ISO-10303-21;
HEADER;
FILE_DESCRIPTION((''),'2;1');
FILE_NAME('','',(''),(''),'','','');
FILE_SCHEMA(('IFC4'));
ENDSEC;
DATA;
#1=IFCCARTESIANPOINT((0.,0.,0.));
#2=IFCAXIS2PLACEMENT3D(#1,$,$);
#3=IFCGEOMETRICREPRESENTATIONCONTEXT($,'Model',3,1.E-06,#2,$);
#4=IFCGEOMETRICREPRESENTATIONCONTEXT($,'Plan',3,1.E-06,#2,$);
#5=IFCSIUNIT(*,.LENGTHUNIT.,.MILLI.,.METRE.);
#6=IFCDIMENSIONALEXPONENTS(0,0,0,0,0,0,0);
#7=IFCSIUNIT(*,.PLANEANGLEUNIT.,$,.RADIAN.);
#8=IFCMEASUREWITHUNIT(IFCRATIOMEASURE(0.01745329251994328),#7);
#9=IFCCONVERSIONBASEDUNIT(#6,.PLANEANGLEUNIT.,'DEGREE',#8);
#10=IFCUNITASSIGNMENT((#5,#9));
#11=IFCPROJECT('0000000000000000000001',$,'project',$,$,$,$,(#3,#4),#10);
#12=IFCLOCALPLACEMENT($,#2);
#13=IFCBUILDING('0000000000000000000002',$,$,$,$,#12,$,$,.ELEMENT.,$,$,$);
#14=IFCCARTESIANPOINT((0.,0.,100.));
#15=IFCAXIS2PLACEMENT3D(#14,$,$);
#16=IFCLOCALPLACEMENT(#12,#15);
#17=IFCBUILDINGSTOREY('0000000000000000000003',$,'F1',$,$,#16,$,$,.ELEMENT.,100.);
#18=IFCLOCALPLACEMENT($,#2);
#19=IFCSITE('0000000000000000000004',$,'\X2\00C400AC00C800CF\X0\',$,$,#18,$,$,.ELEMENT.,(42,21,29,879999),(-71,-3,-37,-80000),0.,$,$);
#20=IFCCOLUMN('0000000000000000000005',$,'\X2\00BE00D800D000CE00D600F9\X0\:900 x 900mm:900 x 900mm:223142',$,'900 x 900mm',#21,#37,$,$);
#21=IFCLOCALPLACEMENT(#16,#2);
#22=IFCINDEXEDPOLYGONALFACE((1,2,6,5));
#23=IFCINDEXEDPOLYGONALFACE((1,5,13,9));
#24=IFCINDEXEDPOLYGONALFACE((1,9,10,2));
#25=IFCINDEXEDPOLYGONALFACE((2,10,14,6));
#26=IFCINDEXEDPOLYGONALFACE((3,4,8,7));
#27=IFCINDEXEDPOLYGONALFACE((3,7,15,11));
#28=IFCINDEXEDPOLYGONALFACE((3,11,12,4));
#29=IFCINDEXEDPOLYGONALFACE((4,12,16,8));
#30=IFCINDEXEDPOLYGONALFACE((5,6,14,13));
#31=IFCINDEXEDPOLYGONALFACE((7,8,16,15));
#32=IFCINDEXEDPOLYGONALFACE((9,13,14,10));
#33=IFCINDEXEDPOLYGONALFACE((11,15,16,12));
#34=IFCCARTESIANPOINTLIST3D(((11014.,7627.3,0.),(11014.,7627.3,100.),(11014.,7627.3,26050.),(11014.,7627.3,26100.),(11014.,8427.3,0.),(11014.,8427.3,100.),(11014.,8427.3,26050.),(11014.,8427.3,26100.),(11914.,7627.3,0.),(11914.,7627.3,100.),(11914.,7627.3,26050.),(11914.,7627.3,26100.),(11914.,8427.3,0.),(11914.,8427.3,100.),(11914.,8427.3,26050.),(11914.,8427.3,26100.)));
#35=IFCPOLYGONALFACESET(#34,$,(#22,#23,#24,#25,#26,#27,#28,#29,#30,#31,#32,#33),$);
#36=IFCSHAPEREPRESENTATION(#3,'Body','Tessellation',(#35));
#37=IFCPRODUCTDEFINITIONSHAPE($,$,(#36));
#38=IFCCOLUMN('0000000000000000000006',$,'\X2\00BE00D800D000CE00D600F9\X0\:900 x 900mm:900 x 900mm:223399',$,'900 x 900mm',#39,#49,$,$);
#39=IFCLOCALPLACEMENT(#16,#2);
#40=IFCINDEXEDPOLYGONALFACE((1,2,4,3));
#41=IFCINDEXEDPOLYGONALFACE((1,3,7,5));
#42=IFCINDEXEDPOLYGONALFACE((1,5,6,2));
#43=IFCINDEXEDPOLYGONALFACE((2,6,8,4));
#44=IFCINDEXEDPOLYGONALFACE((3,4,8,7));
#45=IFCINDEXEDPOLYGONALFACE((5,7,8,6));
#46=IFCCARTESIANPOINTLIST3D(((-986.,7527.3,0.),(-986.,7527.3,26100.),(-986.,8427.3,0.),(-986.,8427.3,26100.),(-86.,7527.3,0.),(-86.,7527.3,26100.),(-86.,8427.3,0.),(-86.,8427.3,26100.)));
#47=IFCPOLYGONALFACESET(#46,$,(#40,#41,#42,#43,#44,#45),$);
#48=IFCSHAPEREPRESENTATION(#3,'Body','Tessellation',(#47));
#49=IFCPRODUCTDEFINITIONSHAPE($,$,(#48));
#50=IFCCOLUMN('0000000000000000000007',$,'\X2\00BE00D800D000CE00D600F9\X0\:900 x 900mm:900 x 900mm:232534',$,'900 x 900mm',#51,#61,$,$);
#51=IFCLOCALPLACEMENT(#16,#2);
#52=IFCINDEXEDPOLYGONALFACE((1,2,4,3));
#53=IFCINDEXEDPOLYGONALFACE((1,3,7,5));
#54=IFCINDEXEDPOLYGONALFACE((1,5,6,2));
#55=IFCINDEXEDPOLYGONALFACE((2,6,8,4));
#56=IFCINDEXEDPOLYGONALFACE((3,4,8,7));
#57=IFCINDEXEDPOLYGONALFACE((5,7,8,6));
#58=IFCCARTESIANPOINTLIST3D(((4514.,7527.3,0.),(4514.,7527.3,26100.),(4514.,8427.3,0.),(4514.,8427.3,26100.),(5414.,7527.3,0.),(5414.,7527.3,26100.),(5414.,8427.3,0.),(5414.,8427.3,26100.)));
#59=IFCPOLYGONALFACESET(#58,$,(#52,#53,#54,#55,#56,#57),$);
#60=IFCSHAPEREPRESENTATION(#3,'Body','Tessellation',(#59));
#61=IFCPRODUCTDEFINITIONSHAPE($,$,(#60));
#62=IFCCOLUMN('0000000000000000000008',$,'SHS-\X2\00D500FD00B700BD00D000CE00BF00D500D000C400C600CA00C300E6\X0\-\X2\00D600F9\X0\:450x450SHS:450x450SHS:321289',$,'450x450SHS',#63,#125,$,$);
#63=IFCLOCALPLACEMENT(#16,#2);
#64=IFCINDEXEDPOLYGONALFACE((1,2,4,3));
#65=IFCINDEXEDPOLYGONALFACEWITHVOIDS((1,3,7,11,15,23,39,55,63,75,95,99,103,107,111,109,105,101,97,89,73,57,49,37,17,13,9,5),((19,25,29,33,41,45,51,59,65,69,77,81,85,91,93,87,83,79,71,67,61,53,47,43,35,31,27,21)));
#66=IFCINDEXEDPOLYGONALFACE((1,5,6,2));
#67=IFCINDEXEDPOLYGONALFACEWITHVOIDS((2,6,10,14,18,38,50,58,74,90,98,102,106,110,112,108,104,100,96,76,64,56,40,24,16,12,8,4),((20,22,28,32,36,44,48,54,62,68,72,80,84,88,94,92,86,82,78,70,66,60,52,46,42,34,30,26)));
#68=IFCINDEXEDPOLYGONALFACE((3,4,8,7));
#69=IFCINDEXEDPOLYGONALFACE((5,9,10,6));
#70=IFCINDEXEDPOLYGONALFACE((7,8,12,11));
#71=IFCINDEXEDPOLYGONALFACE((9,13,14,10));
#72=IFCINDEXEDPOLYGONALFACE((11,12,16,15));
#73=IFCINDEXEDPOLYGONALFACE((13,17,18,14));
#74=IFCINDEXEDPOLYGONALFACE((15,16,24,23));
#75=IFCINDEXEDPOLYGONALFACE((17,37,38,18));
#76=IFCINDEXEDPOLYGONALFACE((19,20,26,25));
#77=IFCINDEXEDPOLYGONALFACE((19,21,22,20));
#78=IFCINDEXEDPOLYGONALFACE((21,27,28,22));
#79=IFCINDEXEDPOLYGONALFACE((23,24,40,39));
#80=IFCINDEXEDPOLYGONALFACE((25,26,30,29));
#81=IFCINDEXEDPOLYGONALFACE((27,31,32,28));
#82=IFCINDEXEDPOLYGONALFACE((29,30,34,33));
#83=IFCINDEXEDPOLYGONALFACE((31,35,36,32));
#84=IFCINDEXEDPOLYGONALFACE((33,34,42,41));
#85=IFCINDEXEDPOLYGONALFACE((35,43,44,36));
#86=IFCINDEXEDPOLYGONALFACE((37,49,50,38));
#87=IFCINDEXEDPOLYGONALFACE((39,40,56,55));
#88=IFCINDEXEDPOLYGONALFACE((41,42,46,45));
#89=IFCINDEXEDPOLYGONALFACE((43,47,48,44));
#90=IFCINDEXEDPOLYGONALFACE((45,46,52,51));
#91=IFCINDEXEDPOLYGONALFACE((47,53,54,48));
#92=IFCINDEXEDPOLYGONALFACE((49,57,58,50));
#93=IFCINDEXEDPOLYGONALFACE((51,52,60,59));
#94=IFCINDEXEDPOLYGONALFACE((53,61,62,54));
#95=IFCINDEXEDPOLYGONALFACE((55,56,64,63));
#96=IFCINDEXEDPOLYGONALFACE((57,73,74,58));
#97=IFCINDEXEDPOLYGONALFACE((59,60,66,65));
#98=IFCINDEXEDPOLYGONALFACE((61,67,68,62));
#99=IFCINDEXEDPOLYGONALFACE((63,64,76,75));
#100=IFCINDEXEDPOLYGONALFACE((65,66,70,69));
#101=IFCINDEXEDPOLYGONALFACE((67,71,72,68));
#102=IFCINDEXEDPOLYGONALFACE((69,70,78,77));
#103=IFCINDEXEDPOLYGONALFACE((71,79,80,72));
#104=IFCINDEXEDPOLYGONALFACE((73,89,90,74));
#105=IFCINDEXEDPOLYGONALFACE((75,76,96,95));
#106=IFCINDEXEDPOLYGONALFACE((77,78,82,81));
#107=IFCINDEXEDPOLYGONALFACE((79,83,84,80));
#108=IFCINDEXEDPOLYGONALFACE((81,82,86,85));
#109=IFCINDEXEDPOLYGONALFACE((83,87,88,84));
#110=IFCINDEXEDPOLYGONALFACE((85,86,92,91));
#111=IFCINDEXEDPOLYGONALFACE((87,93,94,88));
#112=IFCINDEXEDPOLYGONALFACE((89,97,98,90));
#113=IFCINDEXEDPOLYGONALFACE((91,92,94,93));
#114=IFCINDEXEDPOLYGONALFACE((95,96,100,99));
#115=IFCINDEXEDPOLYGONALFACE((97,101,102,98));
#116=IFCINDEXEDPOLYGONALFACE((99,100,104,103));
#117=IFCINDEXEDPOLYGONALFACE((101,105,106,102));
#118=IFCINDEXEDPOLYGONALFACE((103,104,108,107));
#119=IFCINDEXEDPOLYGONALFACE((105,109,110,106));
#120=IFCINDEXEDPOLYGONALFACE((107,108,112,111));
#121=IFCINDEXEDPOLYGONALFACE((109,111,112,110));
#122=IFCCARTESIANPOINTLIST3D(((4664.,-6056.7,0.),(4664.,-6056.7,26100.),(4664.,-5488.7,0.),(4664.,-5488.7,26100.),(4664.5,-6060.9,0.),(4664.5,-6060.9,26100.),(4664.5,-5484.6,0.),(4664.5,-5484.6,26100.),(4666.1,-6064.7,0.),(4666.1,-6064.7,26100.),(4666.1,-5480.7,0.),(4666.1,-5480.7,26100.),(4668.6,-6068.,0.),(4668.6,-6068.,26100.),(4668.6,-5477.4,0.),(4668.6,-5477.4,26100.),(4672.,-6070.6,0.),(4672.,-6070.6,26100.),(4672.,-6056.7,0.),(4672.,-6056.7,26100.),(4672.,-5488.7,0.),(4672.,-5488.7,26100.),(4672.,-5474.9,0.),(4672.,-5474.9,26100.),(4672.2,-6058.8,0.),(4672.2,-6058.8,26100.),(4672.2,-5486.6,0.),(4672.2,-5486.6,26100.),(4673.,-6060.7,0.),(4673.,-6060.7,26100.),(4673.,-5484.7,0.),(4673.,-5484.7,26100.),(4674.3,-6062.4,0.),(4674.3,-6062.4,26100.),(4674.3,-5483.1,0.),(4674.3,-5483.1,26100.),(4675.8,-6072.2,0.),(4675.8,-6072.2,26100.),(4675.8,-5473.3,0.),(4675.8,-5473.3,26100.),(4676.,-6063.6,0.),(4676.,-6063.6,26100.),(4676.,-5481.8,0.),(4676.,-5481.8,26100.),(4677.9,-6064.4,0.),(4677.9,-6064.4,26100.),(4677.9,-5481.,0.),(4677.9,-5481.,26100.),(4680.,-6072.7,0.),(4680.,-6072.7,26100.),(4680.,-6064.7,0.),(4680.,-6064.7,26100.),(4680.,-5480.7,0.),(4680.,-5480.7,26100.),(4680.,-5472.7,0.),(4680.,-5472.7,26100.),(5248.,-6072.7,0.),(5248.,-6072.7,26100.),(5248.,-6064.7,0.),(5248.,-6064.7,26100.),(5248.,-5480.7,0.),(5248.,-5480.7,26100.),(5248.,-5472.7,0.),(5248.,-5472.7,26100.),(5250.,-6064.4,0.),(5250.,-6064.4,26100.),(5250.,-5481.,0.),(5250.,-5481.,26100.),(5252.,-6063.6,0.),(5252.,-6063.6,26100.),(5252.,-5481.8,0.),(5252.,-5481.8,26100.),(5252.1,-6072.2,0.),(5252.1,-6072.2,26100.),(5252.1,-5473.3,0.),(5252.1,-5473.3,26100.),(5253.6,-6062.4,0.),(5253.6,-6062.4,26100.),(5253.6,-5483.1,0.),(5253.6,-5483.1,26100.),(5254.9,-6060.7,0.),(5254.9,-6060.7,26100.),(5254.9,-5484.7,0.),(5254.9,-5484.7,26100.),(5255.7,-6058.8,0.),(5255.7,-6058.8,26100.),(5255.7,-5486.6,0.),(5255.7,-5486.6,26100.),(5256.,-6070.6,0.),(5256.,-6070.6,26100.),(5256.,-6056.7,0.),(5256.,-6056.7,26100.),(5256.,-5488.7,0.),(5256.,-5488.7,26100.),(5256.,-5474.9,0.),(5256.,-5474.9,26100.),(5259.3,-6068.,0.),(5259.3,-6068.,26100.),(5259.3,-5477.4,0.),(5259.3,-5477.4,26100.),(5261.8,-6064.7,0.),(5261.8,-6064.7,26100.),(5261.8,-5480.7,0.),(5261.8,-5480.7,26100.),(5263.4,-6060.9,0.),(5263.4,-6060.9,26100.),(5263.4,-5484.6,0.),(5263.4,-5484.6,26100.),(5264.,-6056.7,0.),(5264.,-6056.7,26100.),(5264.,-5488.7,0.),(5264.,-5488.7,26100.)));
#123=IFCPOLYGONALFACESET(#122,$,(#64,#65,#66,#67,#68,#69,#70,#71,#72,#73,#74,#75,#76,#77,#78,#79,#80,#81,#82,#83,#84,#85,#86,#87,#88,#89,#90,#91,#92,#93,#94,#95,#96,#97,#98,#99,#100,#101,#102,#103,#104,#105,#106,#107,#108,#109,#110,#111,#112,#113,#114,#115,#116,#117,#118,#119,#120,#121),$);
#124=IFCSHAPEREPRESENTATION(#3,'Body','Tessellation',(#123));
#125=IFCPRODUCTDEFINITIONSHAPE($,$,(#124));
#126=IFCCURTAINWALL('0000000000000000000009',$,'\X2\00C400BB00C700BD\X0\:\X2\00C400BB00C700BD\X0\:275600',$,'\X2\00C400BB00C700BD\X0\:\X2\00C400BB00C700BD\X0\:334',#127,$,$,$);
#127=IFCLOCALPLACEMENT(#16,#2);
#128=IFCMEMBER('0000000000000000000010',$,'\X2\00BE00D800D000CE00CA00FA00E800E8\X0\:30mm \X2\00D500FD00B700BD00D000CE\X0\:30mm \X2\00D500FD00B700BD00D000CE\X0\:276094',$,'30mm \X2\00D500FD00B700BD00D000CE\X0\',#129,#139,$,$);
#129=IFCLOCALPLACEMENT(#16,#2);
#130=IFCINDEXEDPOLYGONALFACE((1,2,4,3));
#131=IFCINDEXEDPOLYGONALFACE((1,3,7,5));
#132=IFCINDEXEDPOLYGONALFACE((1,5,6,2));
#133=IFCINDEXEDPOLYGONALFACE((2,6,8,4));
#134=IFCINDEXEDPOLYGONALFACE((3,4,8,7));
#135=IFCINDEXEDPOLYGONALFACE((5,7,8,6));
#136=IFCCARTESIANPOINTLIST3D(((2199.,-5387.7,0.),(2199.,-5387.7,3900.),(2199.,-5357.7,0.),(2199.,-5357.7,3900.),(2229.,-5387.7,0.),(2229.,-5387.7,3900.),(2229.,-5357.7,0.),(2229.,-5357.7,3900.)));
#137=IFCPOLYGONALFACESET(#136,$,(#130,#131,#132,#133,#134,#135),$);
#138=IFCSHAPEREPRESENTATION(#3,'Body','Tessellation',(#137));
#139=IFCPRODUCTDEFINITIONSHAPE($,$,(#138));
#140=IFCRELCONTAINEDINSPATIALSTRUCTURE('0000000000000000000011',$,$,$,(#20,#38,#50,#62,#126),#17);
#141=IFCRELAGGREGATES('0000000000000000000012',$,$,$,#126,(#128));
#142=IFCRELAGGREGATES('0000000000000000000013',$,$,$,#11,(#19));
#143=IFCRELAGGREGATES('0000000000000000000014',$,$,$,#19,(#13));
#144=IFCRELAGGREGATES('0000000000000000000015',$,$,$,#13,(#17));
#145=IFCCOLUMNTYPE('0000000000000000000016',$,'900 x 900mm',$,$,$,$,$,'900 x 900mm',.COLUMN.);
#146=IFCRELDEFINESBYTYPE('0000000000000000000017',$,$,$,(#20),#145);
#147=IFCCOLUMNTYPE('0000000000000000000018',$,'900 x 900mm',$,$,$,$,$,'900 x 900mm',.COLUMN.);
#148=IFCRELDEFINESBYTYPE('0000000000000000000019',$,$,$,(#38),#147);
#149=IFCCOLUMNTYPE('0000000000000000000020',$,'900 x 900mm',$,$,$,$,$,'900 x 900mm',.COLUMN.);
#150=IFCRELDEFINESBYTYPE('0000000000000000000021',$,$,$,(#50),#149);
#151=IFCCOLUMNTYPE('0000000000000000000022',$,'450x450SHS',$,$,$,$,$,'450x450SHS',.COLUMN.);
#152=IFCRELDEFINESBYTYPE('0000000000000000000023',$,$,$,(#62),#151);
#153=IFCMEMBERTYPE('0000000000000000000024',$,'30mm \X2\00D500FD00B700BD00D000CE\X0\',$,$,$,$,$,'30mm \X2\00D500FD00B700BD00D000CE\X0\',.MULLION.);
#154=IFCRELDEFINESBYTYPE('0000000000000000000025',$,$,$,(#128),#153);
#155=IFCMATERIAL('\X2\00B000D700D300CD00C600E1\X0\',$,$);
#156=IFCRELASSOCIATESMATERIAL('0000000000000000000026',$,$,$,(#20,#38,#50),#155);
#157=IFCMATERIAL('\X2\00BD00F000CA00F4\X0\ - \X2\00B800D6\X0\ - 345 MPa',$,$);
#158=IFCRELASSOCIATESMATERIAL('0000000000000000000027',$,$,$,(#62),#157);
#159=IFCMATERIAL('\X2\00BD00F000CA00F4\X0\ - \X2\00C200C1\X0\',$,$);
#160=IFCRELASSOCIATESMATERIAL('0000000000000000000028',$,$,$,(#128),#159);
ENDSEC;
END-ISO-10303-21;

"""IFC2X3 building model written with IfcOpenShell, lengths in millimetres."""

from ifc_helpers import new_model, entity, si_unit, converted_unit, frame, frame_2d, origin, origin_2d_with_axis, place, context, project, spatial, polyline, circle_curve, parameter, trimmed, segment, composite_curve, rectangle, outline, extrude, clip, bounded_halfspace, source, transform, mapped, material, type_object, type_shapes, element, aggregate, save


model = new_model("IFC2X3")

# Units and contexts
model_context = context("Model", 3, precision=1e-06, world=origin())
plan_context = context("Plan", 3, precision=1e-06, world=origin())
ifc_project = project(units=[si_unit("LENGTHUNIT", "METRE", prefix="MILLI"), converted_unit("PLANEANGLEUNIT", "DEGREE", entity("IfcRatioMeasure", 0.01745329251994328), si_unit("PLANEANGLEUNIT", "RADIAN"), dimensions=[0, 0, 0, 0, 0, 0, 0])], contexts=[model_context, plan_context])

# Site, building, storey
site_placement = place(None, origin())
site = spatial("IfcSite", under=ifc_project, at=site_placement, Name="Ä¬ÈÏ", CompositionType="ELEMENT", RefLatitude=(42, 21, 29, 879999), RefLongitude=(-71, -3, -37, -80000), RefElevation=0.0)
building_placement = place(None, origin())
building = spatial("IfcBuilding", under=site, at=building_placement, CompositionType="ELEMENT")
storey_placement = place(building_placement, frame((0.0, 0.0, 100.0)))
storey = spatial("IfcBuildingStorey", under=building, at=storey_placement, Name="F1", CompositionType="ELEMENT", Elevation=100.0)

# Columns
ifc_material_1 = material(Name="°×ÓÍÆá")
column_type_1 = type_object("IfcColumnType", Name="900 x 900mm", ElementType="900 x 900mm", PredefinedType="COLUMN")
shared_shape_1 = source(origin(), model_context, "Body", "Clipping", [
    clip(clip(extrude(rectangle(XDim=900.0, YDim=800.0, at=frame_2d((11464.0, 8027.3), x_axis=(1.0, 0.0))), origin(), (0.0, 0.0, 1.0), 26100.0), bounded_halfspace(frame((11914.0, 7627.3, 26050.0), z_axis=(0.0, 1.0, 0.0), x_axis=(-1.0, 0.0, 0.0)), False, frame((11914.0, 7627.3, 26050.0), z_axis=(0.0, 1.0, 0.0), x_axis=(-1.0, 0.0, 0.0)), polyline([(0.0, 0.0), (0.0, -25950.0), (900.0, -25950.0), (900.0, 0.0), (0.0, 0.0)]))), bounded_halfspace(frame((11014.0, 7627.3, 26050.0), z_axis=(0.0, 0.0, -1.0), x_axis=(1.0, 0.0, 0.0)), False, frame((11014.0, 7627.3, 26050.0), z_axis=(0.0, 0.0, -1.0), x_axis=(1.0, 0.0, 0.0)), polyline([(0.0, 0.0), (900.0, 0.0), (900.0, 100.0), (0.0, 100.0), (0.0, 0.0)]))),
])
type_shapes(column_type_1, [shared_shape_1])
column_1_placement = place(storey_placement, origin())
element("IfcColumn", 1, at=column_1_placement, inside=storey, type_object=column_type_1, material=ifc_material_1, Name="¾ØÐÎÖù:900 x 900mm:900 x 900mm:223142", ObjectType="900 x 900mm", context=model_context, shape_type="MappedRepresentation", body=[
    mapped(shared_shape_1, transform((0.0, 0.0, 0.0), scale=1.0)),
])
column_type_2 = type_object("IfcColumnType", Name="900 x 900mm", ElementType="900 x 900mm", PredefinedType="COLUMN")
shared_shape_2 = source(origin(), model_context, "Body", "SweptSolid", [
    extrude(rectangle(XDim=900.0, YDim=900.0, at=frame_2d((-536.0, 7977.3), x_axis=(0.0, -1.0))), origin(), (0.0, 0.0, 1.0), 26100.0),
])
type_shapes(column_type_2, [shared_shape_2])
column_2_placement = place(storey_placement, origin())
element("IfcColumn", 2, at=column_2_placement, inside=storey, type_object=column_type_2, material=ifc_material_1, Name="¾ØÐÎÖù:900 x 900mm:900 x 900mm:223399", ObjectType="900 x 900mm", context=model_context, shape_type="MappedRepresentation", body=[
    mapped(shared_shape_2, transform((0.0, 0.0, 0.0), scale=1.0)),
])
column_type_3 = type_object("IfcColumnType", Name="900 x 900mm", ElementType="900 x 900mm", PredefinedType="COLUMN")
shared_shape_3 = source(origin(), model_context, "Body", "SweptSolid", [
    extrude(rectangle(XDim=900.0, YDim=900.0, at=frame_2d((4964.0, 7977.3), x_axis=(0.0, -1.0))), origin(), (0.0, 0.0, 1.0), 26100.0),
])
type_shapes(column_type_3, [shared_shape_3])
column_3_placement = place(storey_placement, origin())
element("IfcColumn", 3, at=column_3_placement, inside=storey, type_object=column_type_3, material=ifc_material_1, Name="¾ØÐÎÖù:900 x 900mm:900 x 900mm:232534", ObjectType="900 x 900mm", context=model_context, shape_type="MappedRepresentation", body=[
    mapped(shared_shape_3, transform((0.0, 0.0, 0.0), scale=1.0)),
])
ifc_material_2 = material(Name="½ðÊô - ¸Ö - 345 MPa")
column_type_4 = type_object("IfcColumnType", Name="450x450SHS", ElementType="450x450SHS", PredefinedType="COLUMN")
shared_shape_4 = source(origin(), model_context, "Body", "SweptSolid", [
    extrude(outline(composite_curve([segment(polyline([(-284.0, -300.0), (284.0, -300.0)]), True, "CONTINUOUS"), segment(trimmed(circle_curve(frame_2d((284.0, -284.0), x_axis=(-1.0, 0.0)), 16.0), [parameter(90.0)], [parameter(180.0)], True, "PARAMETER"), True, "CONTINUOUS"), segment(polyline([(300.0, -284.0), (300.0, 284.0)]), True, "CONTINUOUS"), segment(trimmed(circle_curve(frame_2d((284.0, 284.0), x_axis=(-1.0, 0.0)), 16.0), [parameter(180.0)], [parameter(270.0)], True, "PARAMETER"), True, "CONTINUOUS"), segment(polyline([(284.0, 300.0), (-284.0, 300.0)]), True, "CONTINUOUS"), segment(trimmed(circle_curve(frame_2d((-284.0, 284.0), x_axis=(-1.0, 0.0)), 16.0), [parameter(270.0)], [parameter(360.0)], True, "PARAMETER"), True, "CONTINUOUS"), segment(polyline([(-300.0, 284.0), (-300.0, -284.0)]), True, "CONTINUOUS"), segment(trimmed(circle_curve(frame_2d((-284.0, -284.0), x_axis=(-1.0, 0.0)), 16.0), [parameter(360.0)], [parameter(90.0)], True, "PARAMETER"), True, "CONTINUOUS")], self_intersect=False), holes=[composite_curve([segment(trimmed(circle_curve(frame_2d((-284.0, -284.0), x_axis=(-1.0, 0.0)), 8.0), [parameter(0.0)], [parameter(90.0)], True, "PARAMETER"), False, "CONTINUOUS"), segment(polyline([(-292.0, -284.0), (-292.0, 284.0)]), True, "CONTINUOUS"), segment(trimmed(circle_curve(frame_2d((-284.0, 284.0), x_axis=(-1.0, 0.0)), 8.0), [parameter(270.0)], [parameter(360.0)], True, "PARAMETER"), False, "CONTINUOUS"), segment(polyline([(-284.0, 292.0), (284.0, 292.0)]), True, "CONTINUOUS"), segment(trimmed(circle_curve(frame_2d((284.0, 284.0), x_axis=(-1.0, 0.0)), 8.0), [parameter(180.0)], [parameter(270.0)], True, "PARAMETER"), False, "CONTINUOUS"), segment(polyline([(292.0, 284.0), (292.0, -284.0)]), True, "CONTINUOUS"), segment(trimmed(circle_curve(frame_2d((284.0, -284.0), x_axis=(-1.0, 0.0)), 8.0), [parameter(90.0)], [parameter(180.0)], True, "PARAMETER"), False, "CONTINUOUS"), segment(polyline([(284.0, -292.0), (-284.0, -292.0)]), True, "CONTINUOUS")], self_intersect=False)]), frame((0.0, 0.0, 100.0), z_axis=(0.0, 0.0, 1.0), x_axis=(-1.0, 0.0, 0.0)), (0.0, 0.0, 1.0), 26100.0),
])
type_shapes(column_type_4, [shared_shape_4])
column_4_placement = place(storey_placement, frame((4964.0, -5772.7, -100.0)))
element("IfcColumn", 4, at=column_4_placement, inside=storey, type_object=column_type_4, material=ifc_material_2, Name="SHS-Õý·½ÐÎ¿ÕÐÄÆÊÃæ-Öù:450x450SHS:450x450SHS:321289", ObjectType="450x450SHS", context=model_context, shape_type="MappedRepresentation", body=[
    mapped(shared_shape_4, transform((0.0, 0.0, 0.0), scale=1.0)),
])

# Curtain wall, member
curtain_wall_placement = place(storey_placement, origin())
curtain_wall = element("IfcCurtainWall", 5, at=curtain_wall_placement, inside=storey, Name="Ä»Ç½:Ä»Ç½:275600", ObjectType="Ä»Ç½:Ä»Ç½:334")
ifc_material_3 = material(Name="½ðÊô - ÂÁ")
member_type = type_object("IfcMemberType", Name="30mm Õý·½ÐÎ", ElementType="30mm Õý·½ÐÎ", PredefinedType="MULLION")
shared_shape_5 = source(origin(), model_context, "Body", "SweptSolid", [
    extrude(rectangle(XDim=30.0, YDim=30.0, at=origin_2d_with_axis()), frame((0.0, 0.0, -3900.0), z_axis=(0.0, 0.0, 1.0), x_axis=(-1.0, 0.0, 0.0)), (0.0, 0.0, 1.0), 3900.0),
])
type_shapes(member_type, [shared_shape_5])
member_placement = place(storey_placement, frame((2214.0, -5372.7, 0.0), z_axis=(0.0, 0.0, -1.0), x_axis=(1.0, 0.0, 0.0)))
member = element("IfcMember", 6, at=member_placement, type_object=member_type, material=ifc_material_3, Name="¾ØÐÎÊúèè:30mm Õý·½ÐÎ:30mm Õý·½ÐÎ:276094", ObjectType="30mm Õý·½ÐÎ", context=model_context, shape_type="MappedRepresentation", body=[
    mapped(shared_shape_5, transform((0.0, 0.0, 0.0), scale=1.0)),
])

aggregate(curtain_wall, [member])

save(model, "model.ifc")
